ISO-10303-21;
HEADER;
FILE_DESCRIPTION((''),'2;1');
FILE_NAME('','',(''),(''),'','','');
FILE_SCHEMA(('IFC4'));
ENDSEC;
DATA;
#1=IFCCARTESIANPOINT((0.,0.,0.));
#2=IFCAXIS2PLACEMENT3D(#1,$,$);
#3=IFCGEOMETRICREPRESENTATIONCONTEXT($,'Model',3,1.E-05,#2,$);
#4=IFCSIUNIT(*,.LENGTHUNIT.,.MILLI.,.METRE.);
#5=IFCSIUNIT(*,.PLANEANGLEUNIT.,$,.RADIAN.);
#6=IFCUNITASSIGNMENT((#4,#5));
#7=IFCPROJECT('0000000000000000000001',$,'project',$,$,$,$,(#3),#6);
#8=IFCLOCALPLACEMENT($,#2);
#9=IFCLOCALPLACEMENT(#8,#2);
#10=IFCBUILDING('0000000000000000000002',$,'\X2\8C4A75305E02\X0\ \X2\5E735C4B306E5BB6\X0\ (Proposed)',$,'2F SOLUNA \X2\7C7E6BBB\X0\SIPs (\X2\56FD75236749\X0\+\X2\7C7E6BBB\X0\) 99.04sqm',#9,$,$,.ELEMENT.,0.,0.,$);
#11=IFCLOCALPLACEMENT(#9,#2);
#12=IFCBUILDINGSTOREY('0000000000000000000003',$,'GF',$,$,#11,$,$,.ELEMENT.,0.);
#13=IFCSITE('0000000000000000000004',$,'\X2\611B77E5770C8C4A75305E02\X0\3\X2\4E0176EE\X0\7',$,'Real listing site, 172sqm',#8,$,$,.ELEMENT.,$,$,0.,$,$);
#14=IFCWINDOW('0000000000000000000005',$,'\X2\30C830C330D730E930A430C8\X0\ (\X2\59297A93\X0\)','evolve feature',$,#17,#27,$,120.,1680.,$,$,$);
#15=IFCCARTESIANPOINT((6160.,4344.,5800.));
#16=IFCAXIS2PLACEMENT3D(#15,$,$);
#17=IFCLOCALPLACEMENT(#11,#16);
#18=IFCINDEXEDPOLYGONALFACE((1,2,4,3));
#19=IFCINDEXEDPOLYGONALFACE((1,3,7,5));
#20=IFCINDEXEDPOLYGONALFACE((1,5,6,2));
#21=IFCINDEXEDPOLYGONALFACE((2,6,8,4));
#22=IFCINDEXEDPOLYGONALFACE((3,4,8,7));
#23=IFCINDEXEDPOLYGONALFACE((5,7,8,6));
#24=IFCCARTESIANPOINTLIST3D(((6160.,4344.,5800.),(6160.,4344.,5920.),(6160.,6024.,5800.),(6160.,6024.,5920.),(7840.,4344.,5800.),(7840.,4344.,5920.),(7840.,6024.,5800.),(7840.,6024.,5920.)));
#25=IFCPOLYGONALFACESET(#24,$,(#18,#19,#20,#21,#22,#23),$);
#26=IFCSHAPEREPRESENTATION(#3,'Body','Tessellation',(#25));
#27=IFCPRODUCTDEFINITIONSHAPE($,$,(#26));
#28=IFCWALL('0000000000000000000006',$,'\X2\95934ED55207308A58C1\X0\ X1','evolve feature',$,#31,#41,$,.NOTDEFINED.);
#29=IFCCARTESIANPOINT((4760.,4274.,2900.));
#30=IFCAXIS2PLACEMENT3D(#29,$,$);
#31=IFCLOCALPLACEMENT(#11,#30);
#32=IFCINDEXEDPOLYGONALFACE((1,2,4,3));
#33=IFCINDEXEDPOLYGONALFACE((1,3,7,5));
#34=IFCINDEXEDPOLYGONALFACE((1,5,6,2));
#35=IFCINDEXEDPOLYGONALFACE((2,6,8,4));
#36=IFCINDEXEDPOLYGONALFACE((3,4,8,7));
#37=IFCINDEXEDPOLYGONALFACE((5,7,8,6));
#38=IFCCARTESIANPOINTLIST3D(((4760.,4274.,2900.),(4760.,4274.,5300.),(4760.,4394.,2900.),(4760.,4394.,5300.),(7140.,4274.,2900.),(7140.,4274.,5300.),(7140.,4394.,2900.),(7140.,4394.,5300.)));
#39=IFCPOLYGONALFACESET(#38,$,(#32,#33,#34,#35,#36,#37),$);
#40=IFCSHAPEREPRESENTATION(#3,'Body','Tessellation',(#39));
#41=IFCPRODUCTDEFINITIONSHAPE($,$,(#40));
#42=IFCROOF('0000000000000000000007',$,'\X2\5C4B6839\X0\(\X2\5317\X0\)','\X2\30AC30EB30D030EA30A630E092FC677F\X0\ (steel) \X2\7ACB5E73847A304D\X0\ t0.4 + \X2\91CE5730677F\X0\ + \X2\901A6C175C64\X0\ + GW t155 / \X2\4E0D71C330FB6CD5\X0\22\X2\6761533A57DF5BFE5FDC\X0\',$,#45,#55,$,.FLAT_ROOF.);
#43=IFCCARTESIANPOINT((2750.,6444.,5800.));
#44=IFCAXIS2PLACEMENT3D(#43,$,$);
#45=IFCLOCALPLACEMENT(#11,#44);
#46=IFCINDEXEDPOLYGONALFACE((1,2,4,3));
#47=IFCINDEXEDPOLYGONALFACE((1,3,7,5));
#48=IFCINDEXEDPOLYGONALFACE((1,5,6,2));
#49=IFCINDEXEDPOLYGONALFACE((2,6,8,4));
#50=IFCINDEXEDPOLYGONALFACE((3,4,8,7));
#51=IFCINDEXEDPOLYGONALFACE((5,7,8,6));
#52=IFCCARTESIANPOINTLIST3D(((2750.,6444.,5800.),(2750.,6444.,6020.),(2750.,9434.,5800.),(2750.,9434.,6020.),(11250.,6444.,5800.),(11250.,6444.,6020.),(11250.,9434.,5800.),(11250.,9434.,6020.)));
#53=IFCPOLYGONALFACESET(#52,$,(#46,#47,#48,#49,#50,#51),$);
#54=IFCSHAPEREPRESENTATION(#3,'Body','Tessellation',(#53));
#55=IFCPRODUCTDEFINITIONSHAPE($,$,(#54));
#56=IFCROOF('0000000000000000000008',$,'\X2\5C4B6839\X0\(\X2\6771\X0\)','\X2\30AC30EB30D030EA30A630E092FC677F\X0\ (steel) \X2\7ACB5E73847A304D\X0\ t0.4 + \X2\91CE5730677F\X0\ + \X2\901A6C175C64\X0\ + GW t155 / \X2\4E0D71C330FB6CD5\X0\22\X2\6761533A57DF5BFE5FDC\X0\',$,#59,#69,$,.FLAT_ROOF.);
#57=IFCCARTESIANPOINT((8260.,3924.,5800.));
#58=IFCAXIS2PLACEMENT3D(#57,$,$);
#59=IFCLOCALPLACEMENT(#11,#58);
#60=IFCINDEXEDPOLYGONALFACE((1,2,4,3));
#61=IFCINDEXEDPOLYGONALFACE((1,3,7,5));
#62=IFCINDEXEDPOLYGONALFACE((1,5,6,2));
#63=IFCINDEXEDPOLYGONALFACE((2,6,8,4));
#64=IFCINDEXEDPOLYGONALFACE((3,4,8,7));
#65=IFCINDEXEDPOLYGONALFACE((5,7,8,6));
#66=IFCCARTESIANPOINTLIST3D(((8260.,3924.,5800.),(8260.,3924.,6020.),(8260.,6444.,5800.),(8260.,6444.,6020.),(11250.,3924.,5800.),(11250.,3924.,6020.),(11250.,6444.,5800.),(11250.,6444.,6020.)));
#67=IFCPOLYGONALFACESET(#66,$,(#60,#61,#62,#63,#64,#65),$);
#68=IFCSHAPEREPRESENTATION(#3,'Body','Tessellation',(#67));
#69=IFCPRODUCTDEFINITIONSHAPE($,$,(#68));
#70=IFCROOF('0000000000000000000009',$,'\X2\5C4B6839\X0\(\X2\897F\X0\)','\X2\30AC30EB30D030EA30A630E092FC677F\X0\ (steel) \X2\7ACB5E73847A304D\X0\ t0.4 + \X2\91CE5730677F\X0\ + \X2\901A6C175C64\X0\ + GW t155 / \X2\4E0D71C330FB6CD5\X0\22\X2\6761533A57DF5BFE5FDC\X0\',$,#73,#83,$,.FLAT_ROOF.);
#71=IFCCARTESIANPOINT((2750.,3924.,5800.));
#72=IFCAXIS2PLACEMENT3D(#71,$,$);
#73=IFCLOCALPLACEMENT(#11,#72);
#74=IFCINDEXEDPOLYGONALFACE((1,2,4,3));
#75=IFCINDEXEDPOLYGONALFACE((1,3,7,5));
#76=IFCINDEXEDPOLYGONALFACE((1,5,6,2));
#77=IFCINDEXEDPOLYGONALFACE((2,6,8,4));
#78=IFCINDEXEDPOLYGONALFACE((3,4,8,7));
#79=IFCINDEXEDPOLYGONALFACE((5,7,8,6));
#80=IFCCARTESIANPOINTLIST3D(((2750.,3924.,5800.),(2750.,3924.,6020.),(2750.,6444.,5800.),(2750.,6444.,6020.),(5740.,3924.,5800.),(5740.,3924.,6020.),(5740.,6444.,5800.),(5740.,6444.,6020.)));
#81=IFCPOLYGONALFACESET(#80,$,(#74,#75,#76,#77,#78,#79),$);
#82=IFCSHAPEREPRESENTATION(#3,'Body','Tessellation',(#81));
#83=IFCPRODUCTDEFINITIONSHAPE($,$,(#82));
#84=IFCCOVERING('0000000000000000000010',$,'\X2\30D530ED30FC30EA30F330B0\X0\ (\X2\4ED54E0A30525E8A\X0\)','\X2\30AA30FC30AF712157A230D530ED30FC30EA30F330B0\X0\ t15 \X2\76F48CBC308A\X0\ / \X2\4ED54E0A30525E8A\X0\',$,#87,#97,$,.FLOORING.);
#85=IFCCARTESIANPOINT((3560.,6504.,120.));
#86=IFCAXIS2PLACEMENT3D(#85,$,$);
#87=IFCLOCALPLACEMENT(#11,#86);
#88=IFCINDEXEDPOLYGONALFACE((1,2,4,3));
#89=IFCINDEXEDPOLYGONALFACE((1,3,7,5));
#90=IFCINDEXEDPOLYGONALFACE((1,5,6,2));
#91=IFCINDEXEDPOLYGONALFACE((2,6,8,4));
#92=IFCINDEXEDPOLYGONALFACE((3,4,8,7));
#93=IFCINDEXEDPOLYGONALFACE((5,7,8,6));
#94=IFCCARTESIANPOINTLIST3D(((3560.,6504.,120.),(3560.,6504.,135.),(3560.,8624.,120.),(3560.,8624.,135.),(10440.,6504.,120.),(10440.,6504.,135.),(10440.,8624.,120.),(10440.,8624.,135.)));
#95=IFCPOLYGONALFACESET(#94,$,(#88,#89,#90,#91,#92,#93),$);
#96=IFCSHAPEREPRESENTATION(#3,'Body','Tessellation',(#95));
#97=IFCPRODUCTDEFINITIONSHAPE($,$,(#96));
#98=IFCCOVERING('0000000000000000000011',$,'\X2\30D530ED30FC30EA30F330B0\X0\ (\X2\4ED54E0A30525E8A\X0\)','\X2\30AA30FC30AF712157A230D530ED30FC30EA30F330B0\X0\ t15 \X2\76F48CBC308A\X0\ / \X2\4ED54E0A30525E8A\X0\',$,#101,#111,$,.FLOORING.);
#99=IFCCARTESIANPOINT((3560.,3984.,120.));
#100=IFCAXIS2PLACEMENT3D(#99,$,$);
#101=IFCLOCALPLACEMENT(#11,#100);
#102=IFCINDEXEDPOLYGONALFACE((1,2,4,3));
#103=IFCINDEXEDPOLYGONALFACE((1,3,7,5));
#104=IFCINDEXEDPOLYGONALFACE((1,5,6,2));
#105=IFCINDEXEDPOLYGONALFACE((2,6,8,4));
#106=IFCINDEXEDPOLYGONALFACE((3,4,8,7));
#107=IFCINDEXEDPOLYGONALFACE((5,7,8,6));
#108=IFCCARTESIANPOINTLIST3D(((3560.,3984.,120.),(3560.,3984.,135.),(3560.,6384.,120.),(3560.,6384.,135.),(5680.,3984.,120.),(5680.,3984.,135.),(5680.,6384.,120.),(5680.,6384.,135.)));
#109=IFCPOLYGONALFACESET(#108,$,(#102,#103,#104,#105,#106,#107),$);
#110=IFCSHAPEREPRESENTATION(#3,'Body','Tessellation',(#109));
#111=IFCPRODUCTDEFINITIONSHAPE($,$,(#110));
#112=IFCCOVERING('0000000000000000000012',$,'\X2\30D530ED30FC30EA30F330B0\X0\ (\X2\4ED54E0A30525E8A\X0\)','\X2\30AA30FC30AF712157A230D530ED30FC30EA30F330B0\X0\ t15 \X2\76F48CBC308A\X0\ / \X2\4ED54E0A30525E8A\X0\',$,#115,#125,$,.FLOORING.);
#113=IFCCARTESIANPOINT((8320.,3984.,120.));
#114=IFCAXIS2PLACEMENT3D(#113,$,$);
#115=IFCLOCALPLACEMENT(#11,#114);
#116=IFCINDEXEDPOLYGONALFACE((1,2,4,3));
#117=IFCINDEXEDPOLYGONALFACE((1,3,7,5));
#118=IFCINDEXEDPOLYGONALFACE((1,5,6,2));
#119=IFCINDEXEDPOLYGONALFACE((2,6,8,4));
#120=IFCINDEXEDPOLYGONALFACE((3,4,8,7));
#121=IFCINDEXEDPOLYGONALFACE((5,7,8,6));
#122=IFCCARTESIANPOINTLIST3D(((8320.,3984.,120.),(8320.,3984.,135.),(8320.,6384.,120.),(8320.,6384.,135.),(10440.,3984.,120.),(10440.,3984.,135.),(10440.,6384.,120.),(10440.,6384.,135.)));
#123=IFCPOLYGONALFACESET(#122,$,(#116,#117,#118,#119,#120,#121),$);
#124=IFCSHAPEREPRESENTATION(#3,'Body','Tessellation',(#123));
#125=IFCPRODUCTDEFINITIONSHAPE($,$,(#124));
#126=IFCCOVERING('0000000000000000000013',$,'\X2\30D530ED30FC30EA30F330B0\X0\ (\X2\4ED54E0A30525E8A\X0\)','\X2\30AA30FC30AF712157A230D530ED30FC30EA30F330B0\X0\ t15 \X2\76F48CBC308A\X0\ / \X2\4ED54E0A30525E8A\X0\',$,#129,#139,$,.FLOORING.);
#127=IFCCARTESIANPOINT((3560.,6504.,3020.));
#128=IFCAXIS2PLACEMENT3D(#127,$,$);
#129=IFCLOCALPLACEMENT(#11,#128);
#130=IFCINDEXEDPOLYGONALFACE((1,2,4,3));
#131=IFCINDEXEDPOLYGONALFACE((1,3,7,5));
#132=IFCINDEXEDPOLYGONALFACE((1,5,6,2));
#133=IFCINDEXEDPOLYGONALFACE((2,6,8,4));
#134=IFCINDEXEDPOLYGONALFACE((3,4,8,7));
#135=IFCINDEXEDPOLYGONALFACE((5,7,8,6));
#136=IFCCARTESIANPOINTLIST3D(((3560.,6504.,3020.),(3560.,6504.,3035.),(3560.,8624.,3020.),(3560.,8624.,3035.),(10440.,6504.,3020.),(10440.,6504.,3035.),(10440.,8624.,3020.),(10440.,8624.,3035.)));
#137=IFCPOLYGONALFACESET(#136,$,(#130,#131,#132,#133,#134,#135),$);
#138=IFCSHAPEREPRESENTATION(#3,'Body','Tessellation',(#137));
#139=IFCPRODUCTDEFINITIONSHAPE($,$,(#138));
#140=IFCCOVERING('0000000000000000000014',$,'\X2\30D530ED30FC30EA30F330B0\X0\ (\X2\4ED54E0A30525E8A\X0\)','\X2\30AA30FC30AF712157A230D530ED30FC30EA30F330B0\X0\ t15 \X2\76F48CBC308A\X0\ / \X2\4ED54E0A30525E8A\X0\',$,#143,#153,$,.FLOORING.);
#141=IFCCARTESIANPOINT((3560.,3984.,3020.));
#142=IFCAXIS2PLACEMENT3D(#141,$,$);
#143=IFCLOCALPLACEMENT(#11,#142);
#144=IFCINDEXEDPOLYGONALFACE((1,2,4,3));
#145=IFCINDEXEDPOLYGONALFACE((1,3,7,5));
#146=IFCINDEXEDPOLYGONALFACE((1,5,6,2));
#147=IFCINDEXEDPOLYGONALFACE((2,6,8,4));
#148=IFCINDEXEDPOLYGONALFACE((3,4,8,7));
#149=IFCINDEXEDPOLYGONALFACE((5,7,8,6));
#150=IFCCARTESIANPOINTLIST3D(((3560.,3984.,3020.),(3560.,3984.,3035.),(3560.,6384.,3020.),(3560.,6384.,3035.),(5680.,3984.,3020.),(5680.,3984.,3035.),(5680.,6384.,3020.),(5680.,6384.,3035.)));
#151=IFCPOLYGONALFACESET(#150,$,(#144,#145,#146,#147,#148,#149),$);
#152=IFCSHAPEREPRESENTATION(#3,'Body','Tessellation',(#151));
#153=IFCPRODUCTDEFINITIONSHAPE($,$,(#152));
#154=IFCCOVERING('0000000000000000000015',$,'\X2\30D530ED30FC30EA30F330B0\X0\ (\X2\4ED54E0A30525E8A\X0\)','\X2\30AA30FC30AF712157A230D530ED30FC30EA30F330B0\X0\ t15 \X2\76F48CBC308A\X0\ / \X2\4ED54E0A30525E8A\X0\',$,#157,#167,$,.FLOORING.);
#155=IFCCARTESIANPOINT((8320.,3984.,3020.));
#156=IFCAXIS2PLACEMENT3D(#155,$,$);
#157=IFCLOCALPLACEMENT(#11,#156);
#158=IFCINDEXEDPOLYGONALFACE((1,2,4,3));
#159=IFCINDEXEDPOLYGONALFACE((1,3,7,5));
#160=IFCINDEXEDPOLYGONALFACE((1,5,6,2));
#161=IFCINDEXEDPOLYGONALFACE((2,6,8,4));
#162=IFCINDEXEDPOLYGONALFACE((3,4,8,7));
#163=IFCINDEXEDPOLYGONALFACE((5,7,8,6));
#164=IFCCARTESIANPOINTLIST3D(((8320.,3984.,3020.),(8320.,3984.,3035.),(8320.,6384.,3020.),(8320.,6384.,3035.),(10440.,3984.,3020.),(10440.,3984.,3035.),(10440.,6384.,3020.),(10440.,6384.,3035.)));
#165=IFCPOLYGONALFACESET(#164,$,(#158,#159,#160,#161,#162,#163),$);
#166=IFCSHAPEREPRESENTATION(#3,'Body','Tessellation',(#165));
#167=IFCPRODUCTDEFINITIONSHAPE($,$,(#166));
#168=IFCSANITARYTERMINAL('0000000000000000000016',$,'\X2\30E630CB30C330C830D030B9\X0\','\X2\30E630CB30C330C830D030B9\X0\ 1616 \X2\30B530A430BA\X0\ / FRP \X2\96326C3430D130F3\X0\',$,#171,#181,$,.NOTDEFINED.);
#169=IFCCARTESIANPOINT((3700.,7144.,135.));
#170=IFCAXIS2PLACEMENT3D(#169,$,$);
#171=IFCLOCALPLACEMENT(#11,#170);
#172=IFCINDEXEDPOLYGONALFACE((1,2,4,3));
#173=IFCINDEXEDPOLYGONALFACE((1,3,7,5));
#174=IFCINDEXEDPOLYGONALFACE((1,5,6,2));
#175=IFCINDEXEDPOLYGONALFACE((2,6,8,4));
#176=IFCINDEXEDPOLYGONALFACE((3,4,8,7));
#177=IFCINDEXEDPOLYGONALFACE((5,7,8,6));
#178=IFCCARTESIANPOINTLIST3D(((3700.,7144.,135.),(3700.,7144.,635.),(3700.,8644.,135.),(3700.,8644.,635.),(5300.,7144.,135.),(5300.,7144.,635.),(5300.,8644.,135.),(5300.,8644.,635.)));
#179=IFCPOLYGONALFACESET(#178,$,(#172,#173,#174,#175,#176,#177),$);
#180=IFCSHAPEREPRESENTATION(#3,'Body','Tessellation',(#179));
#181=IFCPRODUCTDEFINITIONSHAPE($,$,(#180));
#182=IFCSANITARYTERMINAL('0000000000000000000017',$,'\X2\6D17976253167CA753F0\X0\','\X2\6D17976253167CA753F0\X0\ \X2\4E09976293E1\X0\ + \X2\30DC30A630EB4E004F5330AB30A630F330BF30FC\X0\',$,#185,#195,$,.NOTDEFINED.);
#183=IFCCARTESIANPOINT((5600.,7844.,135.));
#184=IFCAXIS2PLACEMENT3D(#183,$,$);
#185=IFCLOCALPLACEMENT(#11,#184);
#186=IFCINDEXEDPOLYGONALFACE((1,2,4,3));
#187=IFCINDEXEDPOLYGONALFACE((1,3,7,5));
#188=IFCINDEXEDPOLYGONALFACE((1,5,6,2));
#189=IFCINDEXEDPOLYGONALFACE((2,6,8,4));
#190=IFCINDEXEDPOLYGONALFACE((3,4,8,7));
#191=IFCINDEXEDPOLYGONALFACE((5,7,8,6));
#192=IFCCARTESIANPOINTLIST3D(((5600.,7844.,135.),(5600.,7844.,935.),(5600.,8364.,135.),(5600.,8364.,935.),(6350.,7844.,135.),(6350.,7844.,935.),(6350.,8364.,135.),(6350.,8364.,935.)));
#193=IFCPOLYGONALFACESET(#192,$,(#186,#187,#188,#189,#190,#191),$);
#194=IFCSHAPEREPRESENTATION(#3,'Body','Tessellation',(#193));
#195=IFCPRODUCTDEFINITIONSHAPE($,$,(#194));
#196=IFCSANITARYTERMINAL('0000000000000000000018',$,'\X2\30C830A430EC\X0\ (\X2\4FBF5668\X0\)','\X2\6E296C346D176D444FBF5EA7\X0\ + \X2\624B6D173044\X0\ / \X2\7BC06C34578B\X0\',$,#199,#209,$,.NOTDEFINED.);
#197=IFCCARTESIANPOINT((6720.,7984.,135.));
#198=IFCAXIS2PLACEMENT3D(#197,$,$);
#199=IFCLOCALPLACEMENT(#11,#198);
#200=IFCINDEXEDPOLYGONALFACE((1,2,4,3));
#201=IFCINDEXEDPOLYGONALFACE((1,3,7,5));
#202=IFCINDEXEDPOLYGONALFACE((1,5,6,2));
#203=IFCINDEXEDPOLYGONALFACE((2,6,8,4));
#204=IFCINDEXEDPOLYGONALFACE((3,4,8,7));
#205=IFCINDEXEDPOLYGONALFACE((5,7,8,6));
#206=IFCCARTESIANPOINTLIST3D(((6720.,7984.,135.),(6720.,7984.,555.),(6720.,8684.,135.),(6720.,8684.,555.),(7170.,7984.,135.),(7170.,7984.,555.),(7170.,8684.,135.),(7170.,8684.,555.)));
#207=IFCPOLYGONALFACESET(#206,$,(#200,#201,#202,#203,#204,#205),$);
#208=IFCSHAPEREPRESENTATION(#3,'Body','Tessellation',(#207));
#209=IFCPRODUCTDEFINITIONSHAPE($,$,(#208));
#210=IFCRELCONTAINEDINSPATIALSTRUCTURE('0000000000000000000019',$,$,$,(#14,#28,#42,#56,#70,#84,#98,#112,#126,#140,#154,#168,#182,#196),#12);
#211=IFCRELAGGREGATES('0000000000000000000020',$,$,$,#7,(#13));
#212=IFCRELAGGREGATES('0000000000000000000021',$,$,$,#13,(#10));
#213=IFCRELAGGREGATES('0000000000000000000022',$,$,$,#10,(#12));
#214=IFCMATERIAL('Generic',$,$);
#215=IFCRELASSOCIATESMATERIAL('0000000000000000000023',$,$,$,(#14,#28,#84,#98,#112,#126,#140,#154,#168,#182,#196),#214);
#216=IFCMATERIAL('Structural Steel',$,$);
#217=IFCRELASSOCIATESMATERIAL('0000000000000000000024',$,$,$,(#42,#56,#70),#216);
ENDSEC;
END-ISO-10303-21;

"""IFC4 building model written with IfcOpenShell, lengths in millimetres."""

from ifc_helpers import new_model, si_unit, frame, frame_2d, origin, place, context, project, spatial, rectangle, extrude, material, element, save


model = new_model("IFC4")

# Units and contexts
model_context = context("Model", 3, precision=1e-05, world=origin())
ifc_project = project(units=[si_unit("LENGTHUNIT", "METRE", prefix="MILLI"), si_unit("PLANEANGLEUNIT", "RADIAN")], contexts=[model_context])

# Site, building, storey
site_placement = place(None, origin())
site = spatial("IfcSite", under=ifc_project, at=site_placement, Name="愛知県豊田市3丁目7", ObjectType="Real listing site, 172sqm", CompositionType="ELEMENT", RefElevation=0.0)
building_placement = place(site_placement, origin())
building = spatial("IfcBuilding", under=site, at=building_placement, Name="豊田市 平屋の家 (Proposed)", ObjectType="2F SOLUNA 籾殻SIPs (国産杉+籾殻) 99.04sqm", CompositionType="ELEMENT", ElevationOfRefHeight=0.0, ElevationOfTerrain=0.0)
storey_placement = place(building_placement, origin())
storey = spatial("IfcBuildingStorey", under=building, at=storey_placement, Name="GF", CompositionType="ELEMENT", Elevation=0.0)

# Window
ifc_material_1 = material(Name="Generic")
window_1_placement = place(storey_placement, frame((6160.0, 4344.0, 5800.0)))
element("IfcWindow", 1, at=window_1_placement, inside=storey, material=ifc_material_1, Name="トップライト (天窓)", Description="evolve feature", OverallHeight=120.0, OverallWidth=1680.0, context=model_context, shape_type="SweptSolid", body=[
    extrude(rectangle(XDim=1680.0, YDim=1680.0, at=frame_2d((840.0, 840.0))), frame((6160.0, 4344.0, 5800.0)), (0.0, 0.0, 1.0), 120.0),
])

# Wall
wall_1_placement = place(storey_placement, frame((4760.0, 4274.0, 2900.0)))
element("IfcWall", 2, at=wall_1_placement, inside=storey, material=ifc_material_1, Name="間仕切り壁 X1", Description="evolve feature", PredefinedType="NOTDEFINED", context=model_context, shape_type="SweptSolid", body=[
    extrude(rectangle(XDim=2380.0, YDim=120.0, at=frame_2d((1190.0, 60.0))), frame((4760.0, 4274.0, 2900.0)), (0.0, 0.0, 1.0), 2400.0),
])

# Roofs
ifc_material_2 = material(Name="Structural Steel")
roof_1_placement = place(storey_placement, frame((2750.0, 6444.0, 5800.0)))
element("IfcRoof", 3, at=roof_1_placement, inside=storey, material=ifc_material_2, Name="屋根(北)", Description="ガルバリウム鋼板 (steel) 立平葺き t0.4 + 野地板 + 通気層 + GW t155 / 不燃・法22条区域対応", PredefinedType="FLAT_ROOF", context=model_context, shape_type="SweptSolid", body=[
    extrude(rectangle(XDim=8500.0, YDim=2990.0, at=frame_2d((4250.0, 1495.0))), frame((2750.0, 6444.0, 5800.0)), (0.0, 0.0, 1.0), 220.0),
])
roof_2_placement = place(storey_placement, frame((8260.0, 3924.0, 5800.0)))
element("IfcRoof", 4, at=roof_2_placement, inside=storey, material=ifc_material_2, Name="屋根(東)", Description="ガルバリウム鋼板 (steel) 立平葺き t0.4 + 野地板 + 通気層 + GW t155 / 不燃・法22条区域対応", PredefinedType="FLAT_ROOF", context=model_context, shape_type="SweptSolid", body=[
    extrude(rectangle(XDim=2990.0, YDim=2520.0, at=frame_2d((1495.0, 1260.0))), frame((8260.0, 3924.0, 5800.0)), (0.0, 0.0, 1.0), 220.0),
])
roof_3_placement = place(storey_placement, frame((2750.0, 3924.0, 5800.0)))
element("IfcRoof", 5, at=roof_3_placement, inside=storey, material=ifc_material_2, Name="屋根(西)", Description="ガルバリウム鋼板 (steel) 立平葺き t0.4 + 野地板 + 通気層 + GW t155 / 不燃・法22条区域対応", PredefinedType="FLAT_ROOF", context=model_context, shape_type="SweptSolid", body=[
    extrude(rectangle(XDim=2990.0, YDim=2520.0, at=frame_2d((1495.0, 1260.0))), frame((2750.0, 3924.0, 5800.0)), (0.0, 0.0, 1.0), 220.0),
])

# Coverings
covering_1_placement = place(storey_placement, frame((3560.0, 6504.0, 120.0)))
element("IfcCovering", 6, at=covering_1_placement, inside=storey, material=ifc_material_1, Name="フローリング (仕上げ床)", Description="オーク無垢フローリング t15 直貼り / 仕上げ床", PredefinedType="FLOORING", context=model_context, shape_type="SweptSolid", body=[
    extrude(rectangle(XDim=6880.0, YDim=2120.0, at=frame_2d((3440.0, 1060.0))), frame((3560.0, 6504.0, 120.0)), (0.0, 0.0, 1.0), 15.0),
])
covering_2_placement = place(storey_placement, frame((3560.0, 3984.0, 120.0)))
element("IfcCovering", 7, at=covering_2_placement, inside=storey, material=ifc_material_1, Name="フローリング (仕上げ床)", Description="オーク無垢フローリング t15 直貼り / 仕上げ床", PredefinedType="FLOORING", context=model_context, shape_type="SweptSolid", body=[
    extrude(rectangle(XDim=2120.0, YDim=2400.0, at=frame_2d((1060.0, 1200.0))), frame((3560.0, 3984.0, 120.0)), (0.0, 0.0, 1.0), 15.0),
])
covering_3_placement = place(storey_placement, frame((8320.0, 3984.0, 120.0)))
element("IfcCovering", 8, at=covering_3_placement, inside=storey, material=ifc_material_1, Name="フローリング (仕上げ床)", Description="オーク無垢フローリング t15 直貼り / 仕上げ床", PredefinedType="FLOORING", context=model_context, shape_type="SweptSolid", body=[
    extrude(rectangle(XDim=2120.0, YDim=2400.0, at=frame_2d((1060.0, 1200.0))), frame((8320.0, 3984.0, 120.0)), (0.0, 0.0, 1.0), 15.0),
])
covering_4_placement = place(storey_placement, frame((3560.0, 6504.0, 3020.0)))
element("IfcCovering", 9, at=covering_4_placement, inside=storey, material=ifc_material_1, Name="フローリング (仕上げ床)", Description="オーク無垢フローリング t15 直貼り / 仕上げ床", PredefinedType="FLOORING", context=model_context, shape_type="SweptSolid", body=[
    extrude(rectangle(XDim=6880.0, YDim=2120.0, at=frame_2d((3440.0, 1060.0))), frame((3560.0, 6504.0, 3020.0)), (0.0, 0.0, 1.0), 15.0),
])
covering_5_placement = place(storey_placement, frame((3560.0, 3984.0, 3020.0)))
element("IfcCovering", 10, at=covering_5_placement, inside=storey, material=ifc_material_1, Name="フローリング (仕上げ床)", Description="オーク無垢フローリング t15 直貼り / 仕上げ床", PredefinedType="FLOORING", context=model_context, shape_type="SweptSolid", body=[
    extrude(rectangle(XDim=2120.0, YDim=2400.0, at=frame_2d((1060.0, 1200.0))), frame((3560.0, 3984.0, 3020.0)), (0.0, 0.0, 1.0), 15.0),
])
covering_6_placement = place(storey_placement, frame((8320.0, 3984.0, 3020.0)))
element("IfcCovering", 11, at=covering_6_placement, inside=storey, material=ifc_material_1, Name="フローリング (仕上げ床)", Description="オーク無垢フローリング t15 直貼り / 仕上げ床", PredefinedType="FLOORING", context=model_context, shape_type="SweptSolid", body=[
    extrude(rectangle(XDim=2120.0, YDim=2400.0, at=frame_2d((1060.0, 1200.0))), frame((8320.0, 3984.0, 3020.0)), (0.0, 0.0, 1.0), 15.0),
])

# Sanitary terminals
sanitary_terminal_1_placement = place(storey_placement, frame((3700.0, 7144.0, 135.0)))
element("IfcSanitaryTerminal", 12, at=sanitary_terminal_1_placement, inside=storey, material=ifc_material_1, Name="ユニットバス", Description="ユニットバス 1616 サイズ / FRP 防水パン", PredefinedType="NOTDEFINED", context=model_context, shape_type="SweptSolid", body=[
    extrude(rectangle(XDim=1600.0, YDim=1500.0, at=frame_2d((800.0, 750.0))), frame((3700.0, 7144.0, 135.0)), (0.0, 0.0, 1.0), 500.0),
])
sanitary_terminal_2_placement = place(storey_placement, frame((5600.0, 7844.0, 135.0)))
element("IfcSanitaryTerminal", 13, at=sanitary_terminal_2_placement, inside=storey, material=ifc_material_1, Name="洗面化粧台", Description="洗面化粧台 三面鏡 + ボウル一体カウンター", PredefinedType="NOTDEFINED", context=model_context, shape_type="SweptSolid", body=[
    extrude(rectangle(XDim=750.0, YDim=520.0, at=frame_2d((375.0, 260.0))), frame((5600.0, 7844.0, 135.0)), (0.0, 0.0, 1.0), 800.0),
])
sanitary_terminal_3_placement = place(storey_placement, frame((6720.0, 7984.0, 135.0)))
element("IfcSanitaryTerminal", 14, at=sanitary_terminal_3_placement, inside=storey, material=ifc_material_1, Name="トイレ (便器)", Description="温水洗浄便座 + 手洗い / 節水型", PredefinedType="NOTDEFINED", context=model_context, shape_type="SweptSolid", body=[
    extrude(rectangle(XDim=450.0, YDim=700.0, at=frame_2d((225.0, 350.0))), frame((6720.0, 7984.0, 135.0)), (0.0, 0.0, 1.0), 420.0),
])

save(model, "model.ifc")
